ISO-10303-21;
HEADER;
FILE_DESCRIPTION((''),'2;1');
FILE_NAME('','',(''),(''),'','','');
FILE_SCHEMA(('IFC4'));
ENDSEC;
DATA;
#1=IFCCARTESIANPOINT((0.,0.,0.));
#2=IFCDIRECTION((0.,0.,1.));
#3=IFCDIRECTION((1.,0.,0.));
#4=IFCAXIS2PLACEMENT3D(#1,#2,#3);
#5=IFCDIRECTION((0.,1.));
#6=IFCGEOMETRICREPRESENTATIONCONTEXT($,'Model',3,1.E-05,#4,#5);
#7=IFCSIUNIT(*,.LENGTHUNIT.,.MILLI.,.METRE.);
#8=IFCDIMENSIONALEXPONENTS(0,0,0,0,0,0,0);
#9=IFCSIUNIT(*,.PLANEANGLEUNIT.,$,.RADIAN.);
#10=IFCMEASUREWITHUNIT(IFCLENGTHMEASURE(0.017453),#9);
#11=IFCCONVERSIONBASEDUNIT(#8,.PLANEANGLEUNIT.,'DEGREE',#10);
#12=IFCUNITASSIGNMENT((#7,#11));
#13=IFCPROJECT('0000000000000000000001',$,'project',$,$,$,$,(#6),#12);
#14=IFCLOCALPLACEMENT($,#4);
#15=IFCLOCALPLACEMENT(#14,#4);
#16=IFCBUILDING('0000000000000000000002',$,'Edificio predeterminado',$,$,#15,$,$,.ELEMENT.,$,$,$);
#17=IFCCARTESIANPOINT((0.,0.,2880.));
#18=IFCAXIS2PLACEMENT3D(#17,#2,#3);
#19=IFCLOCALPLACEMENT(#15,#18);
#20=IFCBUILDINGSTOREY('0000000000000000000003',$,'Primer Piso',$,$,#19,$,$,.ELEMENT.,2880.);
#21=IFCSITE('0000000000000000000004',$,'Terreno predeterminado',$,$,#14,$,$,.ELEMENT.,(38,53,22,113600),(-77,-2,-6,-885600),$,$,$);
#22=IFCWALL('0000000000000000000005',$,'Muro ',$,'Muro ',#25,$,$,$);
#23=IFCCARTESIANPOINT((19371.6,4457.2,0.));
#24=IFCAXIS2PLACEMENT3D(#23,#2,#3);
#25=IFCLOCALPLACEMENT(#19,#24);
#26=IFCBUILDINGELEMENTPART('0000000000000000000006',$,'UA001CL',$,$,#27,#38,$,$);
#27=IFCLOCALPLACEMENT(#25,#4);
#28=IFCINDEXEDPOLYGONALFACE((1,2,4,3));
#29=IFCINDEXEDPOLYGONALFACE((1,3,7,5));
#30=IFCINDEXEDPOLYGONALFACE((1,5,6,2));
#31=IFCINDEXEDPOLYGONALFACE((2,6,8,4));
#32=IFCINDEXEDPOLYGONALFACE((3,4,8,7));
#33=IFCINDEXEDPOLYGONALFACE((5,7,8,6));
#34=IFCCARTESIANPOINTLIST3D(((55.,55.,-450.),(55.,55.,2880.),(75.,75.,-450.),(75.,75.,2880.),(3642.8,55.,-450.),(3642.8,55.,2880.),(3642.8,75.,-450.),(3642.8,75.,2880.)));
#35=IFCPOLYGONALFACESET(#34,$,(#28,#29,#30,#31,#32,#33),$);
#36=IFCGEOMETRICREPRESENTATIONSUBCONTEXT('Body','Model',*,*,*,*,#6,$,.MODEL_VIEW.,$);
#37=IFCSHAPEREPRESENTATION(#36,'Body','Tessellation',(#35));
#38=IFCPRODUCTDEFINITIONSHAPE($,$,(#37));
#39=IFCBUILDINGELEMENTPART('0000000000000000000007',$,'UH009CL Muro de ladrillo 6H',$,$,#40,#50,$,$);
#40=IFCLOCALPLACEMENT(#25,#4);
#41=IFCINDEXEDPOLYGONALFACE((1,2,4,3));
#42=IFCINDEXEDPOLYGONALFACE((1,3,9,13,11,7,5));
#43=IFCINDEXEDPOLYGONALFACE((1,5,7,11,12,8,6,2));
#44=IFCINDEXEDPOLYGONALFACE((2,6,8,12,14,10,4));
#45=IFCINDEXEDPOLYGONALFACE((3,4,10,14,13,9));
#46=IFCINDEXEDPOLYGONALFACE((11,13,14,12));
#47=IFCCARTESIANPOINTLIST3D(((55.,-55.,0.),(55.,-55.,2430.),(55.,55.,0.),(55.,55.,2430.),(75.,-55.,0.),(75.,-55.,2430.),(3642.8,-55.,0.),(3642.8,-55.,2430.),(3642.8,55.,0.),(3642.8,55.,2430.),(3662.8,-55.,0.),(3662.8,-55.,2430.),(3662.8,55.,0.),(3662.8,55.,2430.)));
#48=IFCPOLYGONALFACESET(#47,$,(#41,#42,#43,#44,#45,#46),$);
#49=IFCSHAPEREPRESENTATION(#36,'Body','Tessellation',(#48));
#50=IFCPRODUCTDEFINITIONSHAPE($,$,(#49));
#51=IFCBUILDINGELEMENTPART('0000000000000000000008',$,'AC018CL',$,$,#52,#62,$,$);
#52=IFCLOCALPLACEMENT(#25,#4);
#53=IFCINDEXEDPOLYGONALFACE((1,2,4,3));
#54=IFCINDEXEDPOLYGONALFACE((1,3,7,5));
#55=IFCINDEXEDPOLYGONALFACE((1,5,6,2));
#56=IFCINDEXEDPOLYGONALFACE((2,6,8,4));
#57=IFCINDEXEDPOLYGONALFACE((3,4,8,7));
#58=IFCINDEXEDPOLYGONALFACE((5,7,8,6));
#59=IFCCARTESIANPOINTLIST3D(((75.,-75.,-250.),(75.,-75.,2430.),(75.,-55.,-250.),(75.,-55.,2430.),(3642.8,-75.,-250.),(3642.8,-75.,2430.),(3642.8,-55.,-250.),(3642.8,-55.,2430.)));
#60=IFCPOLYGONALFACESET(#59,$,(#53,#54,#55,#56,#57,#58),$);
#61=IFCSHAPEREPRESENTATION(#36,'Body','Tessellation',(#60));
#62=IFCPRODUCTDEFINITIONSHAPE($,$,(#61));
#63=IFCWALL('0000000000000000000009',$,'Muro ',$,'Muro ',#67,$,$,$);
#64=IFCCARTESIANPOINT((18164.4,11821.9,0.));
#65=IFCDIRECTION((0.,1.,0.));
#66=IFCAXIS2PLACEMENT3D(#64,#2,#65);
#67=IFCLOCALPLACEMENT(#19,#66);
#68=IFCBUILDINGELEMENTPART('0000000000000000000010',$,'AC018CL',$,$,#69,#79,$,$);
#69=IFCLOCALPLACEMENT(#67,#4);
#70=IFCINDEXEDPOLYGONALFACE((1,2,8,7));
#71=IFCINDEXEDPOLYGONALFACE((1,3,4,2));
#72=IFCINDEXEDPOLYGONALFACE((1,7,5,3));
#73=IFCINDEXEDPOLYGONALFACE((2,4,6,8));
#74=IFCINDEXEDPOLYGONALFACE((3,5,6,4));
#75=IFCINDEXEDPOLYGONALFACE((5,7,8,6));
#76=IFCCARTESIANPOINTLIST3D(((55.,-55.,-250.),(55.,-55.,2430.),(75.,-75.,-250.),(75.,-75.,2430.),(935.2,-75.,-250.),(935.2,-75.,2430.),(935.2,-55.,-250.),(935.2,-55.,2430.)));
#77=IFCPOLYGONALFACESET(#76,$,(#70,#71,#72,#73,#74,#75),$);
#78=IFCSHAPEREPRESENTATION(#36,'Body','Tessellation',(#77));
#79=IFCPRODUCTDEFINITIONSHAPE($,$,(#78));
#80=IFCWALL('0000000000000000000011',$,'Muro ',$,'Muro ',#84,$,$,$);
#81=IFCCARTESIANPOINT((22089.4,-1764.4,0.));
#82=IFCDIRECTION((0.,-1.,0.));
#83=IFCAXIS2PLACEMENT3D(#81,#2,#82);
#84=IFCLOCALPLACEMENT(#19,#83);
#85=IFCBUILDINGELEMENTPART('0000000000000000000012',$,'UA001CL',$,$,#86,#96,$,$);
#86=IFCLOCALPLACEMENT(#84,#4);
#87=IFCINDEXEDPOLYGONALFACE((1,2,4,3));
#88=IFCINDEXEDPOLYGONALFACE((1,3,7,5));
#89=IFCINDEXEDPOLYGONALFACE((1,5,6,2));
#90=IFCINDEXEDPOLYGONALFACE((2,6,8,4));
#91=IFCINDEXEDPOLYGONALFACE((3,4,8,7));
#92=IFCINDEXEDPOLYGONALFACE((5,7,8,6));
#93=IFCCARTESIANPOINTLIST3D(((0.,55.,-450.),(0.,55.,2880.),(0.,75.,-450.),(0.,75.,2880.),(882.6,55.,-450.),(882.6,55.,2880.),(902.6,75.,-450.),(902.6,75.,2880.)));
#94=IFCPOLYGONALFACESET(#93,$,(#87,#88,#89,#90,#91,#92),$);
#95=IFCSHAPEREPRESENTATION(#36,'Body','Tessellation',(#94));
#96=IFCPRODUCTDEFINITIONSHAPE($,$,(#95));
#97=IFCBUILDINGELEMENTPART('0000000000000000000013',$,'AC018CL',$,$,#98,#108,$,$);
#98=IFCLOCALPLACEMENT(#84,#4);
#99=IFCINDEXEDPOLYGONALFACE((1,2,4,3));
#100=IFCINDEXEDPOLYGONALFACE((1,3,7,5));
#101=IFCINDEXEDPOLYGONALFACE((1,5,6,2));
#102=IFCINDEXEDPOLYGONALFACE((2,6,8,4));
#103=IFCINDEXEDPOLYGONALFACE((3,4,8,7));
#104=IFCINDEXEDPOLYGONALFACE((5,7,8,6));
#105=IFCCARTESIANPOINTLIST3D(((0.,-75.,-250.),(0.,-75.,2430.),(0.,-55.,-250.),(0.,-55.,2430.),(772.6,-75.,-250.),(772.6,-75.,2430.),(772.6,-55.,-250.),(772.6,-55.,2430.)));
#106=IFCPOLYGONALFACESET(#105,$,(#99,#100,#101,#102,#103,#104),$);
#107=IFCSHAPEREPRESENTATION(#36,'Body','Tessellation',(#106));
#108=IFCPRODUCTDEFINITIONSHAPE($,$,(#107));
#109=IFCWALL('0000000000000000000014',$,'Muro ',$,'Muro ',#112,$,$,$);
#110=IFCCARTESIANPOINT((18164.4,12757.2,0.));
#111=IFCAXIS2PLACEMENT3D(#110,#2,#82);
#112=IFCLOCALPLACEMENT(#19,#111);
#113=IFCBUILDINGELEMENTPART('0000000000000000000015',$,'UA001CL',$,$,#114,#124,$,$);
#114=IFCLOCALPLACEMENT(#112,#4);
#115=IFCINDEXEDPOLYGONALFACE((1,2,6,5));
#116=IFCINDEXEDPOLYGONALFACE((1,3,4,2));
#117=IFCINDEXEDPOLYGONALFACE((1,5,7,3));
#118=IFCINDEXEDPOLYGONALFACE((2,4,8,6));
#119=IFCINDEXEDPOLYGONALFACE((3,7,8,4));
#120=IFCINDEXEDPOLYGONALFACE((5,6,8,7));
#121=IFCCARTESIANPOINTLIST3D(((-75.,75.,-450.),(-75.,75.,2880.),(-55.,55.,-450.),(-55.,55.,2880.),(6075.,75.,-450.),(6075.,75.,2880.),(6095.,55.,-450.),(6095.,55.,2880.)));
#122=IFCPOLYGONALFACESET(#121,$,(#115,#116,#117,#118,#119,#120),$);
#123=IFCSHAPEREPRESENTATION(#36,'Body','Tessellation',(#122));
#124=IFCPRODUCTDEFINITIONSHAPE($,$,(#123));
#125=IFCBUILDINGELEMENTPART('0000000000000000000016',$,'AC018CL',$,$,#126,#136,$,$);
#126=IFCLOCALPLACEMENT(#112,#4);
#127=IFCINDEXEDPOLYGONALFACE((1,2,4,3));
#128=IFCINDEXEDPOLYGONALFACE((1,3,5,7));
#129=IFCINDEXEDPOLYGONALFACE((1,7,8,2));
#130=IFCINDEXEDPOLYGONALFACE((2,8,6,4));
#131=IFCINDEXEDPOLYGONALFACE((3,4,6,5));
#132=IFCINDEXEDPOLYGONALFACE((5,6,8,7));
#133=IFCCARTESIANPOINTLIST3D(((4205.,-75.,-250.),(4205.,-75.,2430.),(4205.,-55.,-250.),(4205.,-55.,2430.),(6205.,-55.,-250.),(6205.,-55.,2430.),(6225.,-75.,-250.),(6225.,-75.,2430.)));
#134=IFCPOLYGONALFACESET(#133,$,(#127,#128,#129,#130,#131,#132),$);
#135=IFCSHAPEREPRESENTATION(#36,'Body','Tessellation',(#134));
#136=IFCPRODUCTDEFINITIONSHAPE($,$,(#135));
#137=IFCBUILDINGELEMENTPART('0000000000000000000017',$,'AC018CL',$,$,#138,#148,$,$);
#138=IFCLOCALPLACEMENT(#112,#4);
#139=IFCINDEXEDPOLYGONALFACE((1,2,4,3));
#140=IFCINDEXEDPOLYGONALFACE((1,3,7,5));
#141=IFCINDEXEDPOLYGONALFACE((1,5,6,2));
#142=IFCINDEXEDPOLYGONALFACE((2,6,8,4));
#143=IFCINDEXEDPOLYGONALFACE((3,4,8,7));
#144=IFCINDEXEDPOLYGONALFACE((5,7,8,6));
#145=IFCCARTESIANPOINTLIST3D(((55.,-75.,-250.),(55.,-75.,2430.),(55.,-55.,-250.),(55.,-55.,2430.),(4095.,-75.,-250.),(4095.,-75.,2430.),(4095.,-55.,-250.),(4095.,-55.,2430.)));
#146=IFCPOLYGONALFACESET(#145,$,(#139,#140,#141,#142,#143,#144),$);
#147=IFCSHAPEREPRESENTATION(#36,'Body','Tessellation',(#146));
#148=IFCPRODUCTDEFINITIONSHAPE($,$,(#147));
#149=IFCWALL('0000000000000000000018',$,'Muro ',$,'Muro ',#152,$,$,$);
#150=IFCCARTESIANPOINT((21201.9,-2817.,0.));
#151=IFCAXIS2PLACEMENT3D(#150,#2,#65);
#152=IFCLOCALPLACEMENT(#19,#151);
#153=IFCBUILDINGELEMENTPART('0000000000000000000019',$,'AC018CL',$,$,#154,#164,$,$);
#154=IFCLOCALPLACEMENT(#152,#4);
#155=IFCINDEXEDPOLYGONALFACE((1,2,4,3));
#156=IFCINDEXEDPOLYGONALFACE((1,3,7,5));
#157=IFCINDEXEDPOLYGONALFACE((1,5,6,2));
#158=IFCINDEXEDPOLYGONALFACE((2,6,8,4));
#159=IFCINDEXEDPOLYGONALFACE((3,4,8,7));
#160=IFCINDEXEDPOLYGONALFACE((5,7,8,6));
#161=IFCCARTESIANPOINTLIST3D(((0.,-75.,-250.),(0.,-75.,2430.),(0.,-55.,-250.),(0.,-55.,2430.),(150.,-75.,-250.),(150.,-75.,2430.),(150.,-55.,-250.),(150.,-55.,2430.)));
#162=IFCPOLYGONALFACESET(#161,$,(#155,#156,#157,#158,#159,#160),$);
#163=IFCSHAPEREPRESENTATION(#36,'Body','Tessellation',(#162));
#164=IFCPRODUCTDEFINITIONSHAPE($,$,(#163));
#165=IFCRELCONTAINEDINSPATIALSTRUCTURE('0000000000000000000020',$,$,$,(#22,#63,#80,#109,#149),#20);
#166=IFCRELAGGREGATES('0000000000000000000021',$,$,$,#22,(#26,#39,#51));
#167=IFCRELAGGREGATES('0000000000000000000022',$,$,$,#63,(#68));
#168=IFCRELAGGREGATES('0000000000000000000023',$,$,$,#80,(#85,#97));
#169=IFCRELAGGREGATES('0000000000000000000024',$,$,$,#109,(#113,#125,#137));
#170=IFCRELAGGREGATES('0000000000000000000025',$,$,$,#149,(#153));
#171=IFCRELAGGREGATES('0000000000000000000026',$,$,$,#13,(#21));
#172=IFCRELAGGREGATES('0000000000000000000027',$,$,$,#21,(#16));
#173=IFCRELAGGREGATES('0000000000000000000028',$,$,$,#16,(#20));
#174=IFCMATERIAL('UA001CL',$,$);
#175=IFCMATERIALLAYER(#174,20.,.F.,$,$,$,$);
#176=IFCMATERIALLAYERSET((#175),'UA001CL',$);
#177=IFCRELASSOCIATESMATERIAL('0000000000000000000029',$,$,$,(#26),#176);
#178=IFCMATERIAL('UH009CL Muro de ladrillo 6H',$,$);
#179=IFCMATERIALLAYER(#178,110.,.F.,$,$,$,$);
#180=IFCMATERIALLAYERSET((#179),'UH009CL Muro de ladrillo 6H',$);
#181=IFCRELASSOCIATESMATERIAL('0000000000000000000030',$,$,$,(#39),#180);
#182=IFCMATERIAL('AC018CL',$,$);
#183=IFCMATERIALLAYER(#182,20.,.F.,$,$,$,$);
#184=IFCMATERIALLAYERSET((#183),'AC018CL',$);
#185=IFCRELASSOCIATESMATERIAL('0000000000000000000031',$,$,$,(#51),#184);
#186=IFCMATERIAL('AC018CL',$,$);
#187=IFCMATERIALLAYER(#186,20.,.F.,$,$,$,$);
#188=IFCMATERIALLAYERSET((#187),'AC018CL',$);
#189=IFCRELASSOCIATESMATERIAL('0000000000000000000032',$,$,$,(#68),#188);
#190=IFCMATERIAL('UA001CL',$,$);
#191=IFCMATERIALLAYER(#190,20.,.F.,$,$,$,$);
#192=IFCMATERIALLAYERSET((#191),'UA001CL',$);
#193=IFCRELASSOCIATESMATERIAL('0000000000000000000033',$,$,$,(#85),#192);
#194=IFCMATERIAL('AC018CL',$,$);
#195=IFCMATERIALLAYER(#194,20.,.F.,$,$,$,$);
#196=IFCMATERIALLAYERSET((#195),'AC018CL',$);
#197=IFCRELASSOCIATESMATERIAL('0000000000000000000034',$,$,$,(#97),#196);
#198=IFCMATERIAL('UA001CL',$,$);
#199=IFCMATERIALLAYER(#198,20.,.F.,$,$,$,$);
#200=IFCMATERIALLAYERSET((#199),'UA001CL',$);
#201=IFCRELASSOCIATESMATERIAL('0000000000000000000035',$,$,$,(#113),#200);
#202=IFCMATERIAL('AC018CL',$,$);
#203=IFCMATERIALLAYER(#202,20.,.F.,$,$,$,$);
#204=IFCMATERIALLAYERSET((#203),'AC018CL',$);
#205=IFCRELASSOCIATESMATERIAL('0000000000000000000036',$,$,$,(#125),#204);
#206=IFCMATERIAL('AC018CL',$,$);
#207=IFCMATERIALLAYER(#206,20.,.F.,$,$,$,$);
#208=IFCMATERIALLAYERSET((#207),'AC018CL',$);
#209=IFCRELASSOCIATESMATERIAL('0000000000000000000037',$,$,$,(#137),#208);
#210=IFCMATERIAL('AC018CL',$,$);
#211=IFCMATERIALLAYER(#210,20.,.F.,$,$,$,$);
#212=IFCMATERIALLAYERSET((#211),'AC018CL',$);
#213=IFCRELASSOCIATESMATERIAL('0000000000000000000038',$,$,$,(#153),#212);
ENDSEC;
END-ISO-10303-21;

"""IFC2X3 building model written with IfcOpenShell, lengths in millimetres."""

from ifc_helpers import new_model, entity, si_unit, converted_unit, direction, frame, origin_with_axes, place, context, subcontext, project, spatial, polyline, outline, extrude, clip, bounded_halfspace, material, layer, layer_set, layer_usage, element, aggregate, save


model = new_model("IFC2X3")

# Units and contexts
model_context = context("Model", 3, precision=1e-05, world=origin_with_axes(), true_north=direction((0.0, 1.0)))
body_context = subcontext(model_context, "Body", "Model", "MODEL_VIEW")
ifc_project = project(units=[si_unit("LENGTHUNIT", "METRE", prefix="MILLI"), converted_unit("PLANEANGLEUNIT", "DEGREE", entity("IfcLengthMeasure", 0.017453), si_unit("PLANEANGLEUNIT", "RADIAN"), dimensions=[0, 0, 0, 0, 0, 0, 0])], contexts=[model_context])

# Site, building, storey
site_placement = place(None, origin_with_axes())
site = spatial("IfcSite", under=ifc_project, at=site_placement, Name="Terreno predeterminado", CompositionType="ELEMENT", RefLatitude=(38, 53, 22, 113600), RefLongitude=(-77, -2, -6, -885600))
building_placement = place(site_placement, origin_with_axes())
building = spatial("IfcBuilding", under=site, at=building_placement, Name="Edificio predeterminado", CompositionType="ELEMENT")
storey_placement = place(building_placement, frame((0.0, 0.0, 2880.0), z_axis=(0.0, 0.0, 1.0), x_axis=(1.0, 0.0, 0.0)))
storey = spatial("IfcBuildingStorey", under=building, at=storey_placement, Name="Primer Piso", CompositionType="ELEMENT", Elevation=2880.0)

# Walls, building element parts
wall_1_placement = place(storey_placement, frame((19371.6, 4457.2, 0.0), z_axis=(0.0, 0.0, 1.0), x_axis=(1.0, 0.0, 0.0)))
wall_1 = element("IfcWall", 1, at=wall_1_placement, inside=storey, Name="Muro ", ObjectType="Muro ")
ifc_material_1 = material(Name="UA001CL")
ifc_layer_1 = layer(ifc_material_1, 20.0, ventilated=False)
ifc_layer_set_1 = layer_set([ifc_layer_1], Name="UA001CL")
ifc_layer_usage_1 = layer_usage(ifc_layer_set_1, "AXIS2", "NEGATIVE", -75.0)
building_element_part_1_placement = place(wall_1_placement, origin_with_axes())
building_element_part_1 = element("IfcBuildingElementPart", 2, at=building_element_part_1_placement, material=ifc_layer_usage_1, Name="UA001CL", context=body_context, shape_type="SweptSolid", body=[
    extrude(outline(polyline([(3642.8, 75.0), (3642.8, 55.0), (55.0, 55.0), (75.0, 75.0), (3642.8, 75.0)])), frame((0.0, 0.0, -450.0), z_axis=(0.0, 0.0, 1.0), x_axis=(1.0, 0.0, 0.0)), (0.0, 0.0, 1.0), 3330.0),
])
ifc_material_2 = material(Name="UH009CL Muro de ladrillo 6H")
ifc_layer_2 = layer(ifc_material_2, 110.0, ventilated=False)
ifc_layer_set_2 = layer_set([ifc_layer_2], Name="UH009CL Muro de ladrillo 6H")
ifc_layer_usage_2 = layer_usage(ifc_layer_set_2, "AXIS2", "NEGATIVE", -55.0)
building_element_part_2_placement = place(wall_1_placement, origin_with_axes())
building_element_part_2 = element("IfcBuildingElementPart", 3, at=building_element_part_2_placement, material=ifc_layer_usage_2, Name="UH009CL Muro de ladrillo 6H", context=body_context, shape_type="SweptSolid", body=[
    extrude(outline(polyline([(3662.8, 55.0), (3662.8, -55.0), (3642.8, -55.0), (75.0, -55.0), (55.0, -55.0), (55.0, 55.0), (3642.8, 55.0), (3662.8, 55.0)])), origin_with_axes(), (0.0, 0.0, 1.0), 2430.0),
])
ifc_material_3 = material(Name="AC018CL")
ifc_layer_3 = layer(ifc_material_3, 20.0, ventilated=False)
ifc_layer_set_3 = layer_set([ifc_layer_3], Name="AC018CL")
ifc_layer_usage_3 = layer_usage(ifc_layer_set_3, "AXIS2", "NEGATIVE", 55.0)
building_element_part_3_placement = place(wall_1_placement, origin_with_axes())
building_element_part_3 = element("IfcBuildingElementPart", 4, at=building_element_part_3_placement, material=ifc_layer_usage_3, Name="AC018CL", context=body_context, shape_type="SweptSolid", body=[
    extrude(outline(polyline([(3642.8, -55.0), (3642.8, -75.0), (75.0, -75.0), (75.0, -55.0), (3642.8, -55.0)])), frame((0.0, 0.0, -250.0), z_axis=(0.0, 0.0, 1.0), x_axis=(1.0, 0.0, 0.0)), (0.0, 0.0, 1.0), 2680.0),
])
aggregate(wall_1, [building_element_part_1, building_element_part_2, building_element_part_3])
wall_2_placement = place(storey_placement, frame((18164.4, 11821.9, 0.0), z_axis=(0.0, 0.0, 1.0), x_axis=(0.0, 1.0, 0.0)))
wall_2 = element("IfcWall", 5, at=wall_2_placement, inside=storey, Name="Muro ", ObjectType="Muro ")
ifc_material_4 = material(Name="AC018CL")
ifc_layer_4 = layer(ifc_material_4, 20.0, ventilated=False)
ifc_layer_set_4 = layer_set([ifc_layer_4], Name="AC018CL")
ifc_layer_usage_4 = layer_usage(ifc_layer_set_4, "AXIS2", "NEGATIVE", 55.0)
building_element_part_4_placement = place(wall_2_placement, origin_with_axes())
building_element_part_4 = element("IfcBuildingElementPart", 6, at=building_element_part_4_placement, material=ifc_layer_usage_4, Name="AC018CL", context=body_context, shape_type="SweptSolid", body=[
    extrude(outline(polyline([(935.2, -55.0), (935.2, -75.0), (75.0, -75.0), (55.0, -55.0), (935.2, -55.0)])), frame((0.0, 0.0, -250.0), z_axis=(0.0, 0.0, 1.0), x_axis=(1.0, 0.0, 0.0)), (0.0, 0.0, 1.0), 2680.0),
])
aggregate(wall_2, [building_element_part_4])
wall_3_placement = place(storey_placement, frame((22089.4, -1764.4, 0.0), z_axis=(0.0, 0.0, 1.0), x_axis=(0.0, -1.0, 0.0)))
wall_3 = element("IfcWall", 7, at=wall_3_placement, inside=storey, Name="Muro ", ObjectType="Muro ")
ifc_material_5 = material(Name="UA001CL")
ifc_layer_5 = layer(ifc_material_5, 20.0, ventilated=False)
ifc_layer_set_5 = layer_set([ifc_layer_5], Name="UA001CL")
ifc_layer_usage_5 = layer_usage(ifc_layer_set_5, "AXIS2", "NEGATIVE", -75.0)
building_element_part_5_placement = place(wall_3_placement, origin_with_axes())
building_element_part_5 = element("IfcBuildingElementPart", 8, at=building_element_part_5_placement, material=ifc_layer_usage_5, Name="UA001CL", context=body_context, shape_type="SweptSolid", body=[
    extrude(outline(polyline([(902.6, 75.0), (882.6, 55.0), (0.0, 55.0), (0.0, 75.0), (902.6, 75.0)])), frame((0.0, 0.0, -450.0), z_axis=(0.0, 0.0, 1.0), x_axis=(1.0, 0.0, 0.0)), (0.0, 0.0, 1.0), 3330.0),
])
ifc_material_6 = material(Name="AC018CL")
ifc_layer_6 = layer(ifc_material_6, 20.0, ventilated=False)
ifc_layer_set_6 = layer_set([ifc_layer_6], Name="AC018CL")
ifc_layer_usage_6 = layer_usage(ifc_layer_set_6, "AXIS2", "NEGATIVE", 55.0)
building_element_part_6_placement = place(wall_3_placement, origin_with_axes())
building_element_part_6 = element("IfcBuildingElementPart", 9, at=building_element_part_6_placement, material=ifc_layer_usage_6, Name="AC018CL", context=body_context, shape_type="SweptSolid", body=[
    extrude(outline(polyline([(772.6, -55.0), (772.6, -75.0), (0.0, -75.0), (0.0, -55.0), (772.6, -55.0)])), frame((0.0, 0.0, -250.0), z_axis=(0.0, 0.0, 1.0), x_axis=(1.0, 0.0, 0.0)), (0.0, 0.0, 1.0), 2680.0),
])
aggregate(wall_3, [building_element_part_5, building_element_part_6])
wall_4_placement = place(storey_placement, frame((18164.4, 12757.2, 0.0), z_axis=(0.0, 0.0, 1.0), x_axis=(0.0, -1.0, 0.0)))
wall_4 = element("IfcWall", 10, at=wall_4_placement, inside=storey, Name="Muro ", ObjectType="Muro ")
ifc_material_7 = material(Name="UA001CL")
ifc_layer_7 = layer(ifc_material_7, 20.0, ventilated=False)
ifc_layer_set_7 = layer_set([ifc_layer_7], Name="UA001CL")
ifc_layer_usage_7 = layer_usage(ifc_layer_set_7, "AXIS2", "NEGATIVE", -75.0)
building_element_part_7_placement = place(wall_4_placement, origin_with_axes())
building_element_part_7 = element("IfcBuildingElementPart", 11, at=building_element_part_7_placement, material=ifc_layer_usage_7, Name="UA001CL", context=body_context, shape_type="SweptSolid", body=[
    extrude(outline(polyline([(6075.0, 75.0), (6095.0, 55.0), (-55.0, 55.0), (-75.0, 75.0), (6075.0, 75.0)])), frame((0.0, 0.0, -450.0), z_axis=(0.0, 0.0, 1.0), x_axis=(1.0, 0.0, 0.0)), (0.0, 0.0, 1.0), 3330.0),
])
ifc_material_8 = material(Name="AC018CL")
ifc_layer_8 = layer(ifc_material_8, 20.0, ventilated=False)
ifc_layer_set_8 = layer_set([ifc_layer_8], Name="AC018CL")
ifc_layer_usage_8 = layer_usage(ifc_layer_set_8, "AXIS2", "NEGATIVE", 55.0)
building_element_part_8_placement = place(wall_4_placement, origin_with_axes())
building_element_part_8 = element("IfcBuildingElementPart", 12, at=building_element_part_8_placement, material=ifc_layer_usage_8, Name="AC018CL", context=body_context, shape_type="SweptSolid", body=[
    extrude(outline(polyline([(6205.0, -55.0), (6225.0, -75.0), (4205.0, -75.0), (4205.0, -55.0), (6205.0, -55.0)])), frame((0.0, 0.0, -250.0), z_axis=(0.0, 0.0, 1.0), x_axis=(1.0, 0.0, 0.0)), (0.0, 0.0, 1.0), 2680.0),
])
ifc_material_9 = material(Name="AC018CL")
ifc_layer_9 = layer(ifc_material_9, 20.0, ventilated=False)
ifc_layer_set_9 = layer_set([ifc_layer_9], Name="AC018CL")
ifc_layer_usage_9 = layer_usage(ifc_layer_set_9, "AXIS2", "NEGATIVE", 55.0)
building_element_part_9_placement = place(wall_4_placement, origin_with_axes())
building_element_part_9 = element("IfcBuildingElementPart", 13, at=building_element_part_9_placement, material=ifc_layer_usage_9, Name="AC018CL", context=body_context, shape_type="SweptSolid", body=[
    extrude(outline(polyline([(4095.0, -55.0), (4095.0, -75.0), (55.0, -75.0), (55.0, -55.0), (4095.0, -55.0)])), frame((0.0, 0.0, -250.0), z_axis=(0.0, 0.0, 1.0), x_axis=(1.0, 0.0, 0.0)), (0.0, 0.0, 1.0), 2680.0),
])
aggregate(wall_4, [building_element_part_7, building_element_part_8, building_element_part_9])
wall_5_placement = place(storey_placement, frame((21201.9, -2817.0, 0.0), z_axis=(0.0, 0.0, 1.0), x_axis=(0.0, 1.0, 0.0)))
wall_5 = element("IfcWall", 14, at=wall_5_placement, inside=storey, Name="Muro ", ObjectType="Muro ")
ifc_material_10 = material(Name="AC018CL")
ifc_layer_10 = layer(ifc_material_10, 20.0, ventilated=False)
ifc_layer_set_10 = layer_set([ifc_layer_10], Name="AC018CL")
ifc_layer_usage_10 = layer_usage(ifc_layer_set_10, "AXIS2", "NEGATIVE", 55.0)
building_element_part_10_placement = place(wall_5_placement, origin_with_axes())
building_element_part_10 = element("IfcBuildingElementPart", 15, at=building_element_part_10_placement, material=ifc_layer_usage_10, Name="AC018CL", context=body_context, shape_type="Clipping", body=[
    clip(clip(extrude(outline(polyline([(150.0, -55.0), (150.0, -75.0), (0.0, -75.0), (0.0, -55.0), (150.0, -55.0)])), frame((0.0, 0.0, -250.0), z_axis=(0.0, 0.0, 1.0), x_axis=(1.0, 0.0, 0.0)), (0.0, 0.0, 1.0), 2680.0), bounded_halfspace(frame((0.0, 0.0, -250.0), z_axis=(0.0, 0.0, 1.0), x_axis=(1.0, 0.0, 0.0)), True, origin_with_axes(), polyline([(-150.0, -150.0), (375.0, -150.0), (375.0, 150.0), (-150.0, 150.0), (-150.0, -150.0)]))), bounded_halfspace(frame((0.0, 0.0, 2430.0), z_axis=(0.0, 0.0, 1.0), x_axis=(1.0, 0.0, 0.0)), False, origin_with_axes(), polyline([(-150.0, -150.0), (375.0, -150.0), (375.0, 150.0), (-150.0, 150.0), (-150.0, -150.0)]))),
])
aggregate(wall_5, [building_element_part_10])

save(model, "model.ifc")
